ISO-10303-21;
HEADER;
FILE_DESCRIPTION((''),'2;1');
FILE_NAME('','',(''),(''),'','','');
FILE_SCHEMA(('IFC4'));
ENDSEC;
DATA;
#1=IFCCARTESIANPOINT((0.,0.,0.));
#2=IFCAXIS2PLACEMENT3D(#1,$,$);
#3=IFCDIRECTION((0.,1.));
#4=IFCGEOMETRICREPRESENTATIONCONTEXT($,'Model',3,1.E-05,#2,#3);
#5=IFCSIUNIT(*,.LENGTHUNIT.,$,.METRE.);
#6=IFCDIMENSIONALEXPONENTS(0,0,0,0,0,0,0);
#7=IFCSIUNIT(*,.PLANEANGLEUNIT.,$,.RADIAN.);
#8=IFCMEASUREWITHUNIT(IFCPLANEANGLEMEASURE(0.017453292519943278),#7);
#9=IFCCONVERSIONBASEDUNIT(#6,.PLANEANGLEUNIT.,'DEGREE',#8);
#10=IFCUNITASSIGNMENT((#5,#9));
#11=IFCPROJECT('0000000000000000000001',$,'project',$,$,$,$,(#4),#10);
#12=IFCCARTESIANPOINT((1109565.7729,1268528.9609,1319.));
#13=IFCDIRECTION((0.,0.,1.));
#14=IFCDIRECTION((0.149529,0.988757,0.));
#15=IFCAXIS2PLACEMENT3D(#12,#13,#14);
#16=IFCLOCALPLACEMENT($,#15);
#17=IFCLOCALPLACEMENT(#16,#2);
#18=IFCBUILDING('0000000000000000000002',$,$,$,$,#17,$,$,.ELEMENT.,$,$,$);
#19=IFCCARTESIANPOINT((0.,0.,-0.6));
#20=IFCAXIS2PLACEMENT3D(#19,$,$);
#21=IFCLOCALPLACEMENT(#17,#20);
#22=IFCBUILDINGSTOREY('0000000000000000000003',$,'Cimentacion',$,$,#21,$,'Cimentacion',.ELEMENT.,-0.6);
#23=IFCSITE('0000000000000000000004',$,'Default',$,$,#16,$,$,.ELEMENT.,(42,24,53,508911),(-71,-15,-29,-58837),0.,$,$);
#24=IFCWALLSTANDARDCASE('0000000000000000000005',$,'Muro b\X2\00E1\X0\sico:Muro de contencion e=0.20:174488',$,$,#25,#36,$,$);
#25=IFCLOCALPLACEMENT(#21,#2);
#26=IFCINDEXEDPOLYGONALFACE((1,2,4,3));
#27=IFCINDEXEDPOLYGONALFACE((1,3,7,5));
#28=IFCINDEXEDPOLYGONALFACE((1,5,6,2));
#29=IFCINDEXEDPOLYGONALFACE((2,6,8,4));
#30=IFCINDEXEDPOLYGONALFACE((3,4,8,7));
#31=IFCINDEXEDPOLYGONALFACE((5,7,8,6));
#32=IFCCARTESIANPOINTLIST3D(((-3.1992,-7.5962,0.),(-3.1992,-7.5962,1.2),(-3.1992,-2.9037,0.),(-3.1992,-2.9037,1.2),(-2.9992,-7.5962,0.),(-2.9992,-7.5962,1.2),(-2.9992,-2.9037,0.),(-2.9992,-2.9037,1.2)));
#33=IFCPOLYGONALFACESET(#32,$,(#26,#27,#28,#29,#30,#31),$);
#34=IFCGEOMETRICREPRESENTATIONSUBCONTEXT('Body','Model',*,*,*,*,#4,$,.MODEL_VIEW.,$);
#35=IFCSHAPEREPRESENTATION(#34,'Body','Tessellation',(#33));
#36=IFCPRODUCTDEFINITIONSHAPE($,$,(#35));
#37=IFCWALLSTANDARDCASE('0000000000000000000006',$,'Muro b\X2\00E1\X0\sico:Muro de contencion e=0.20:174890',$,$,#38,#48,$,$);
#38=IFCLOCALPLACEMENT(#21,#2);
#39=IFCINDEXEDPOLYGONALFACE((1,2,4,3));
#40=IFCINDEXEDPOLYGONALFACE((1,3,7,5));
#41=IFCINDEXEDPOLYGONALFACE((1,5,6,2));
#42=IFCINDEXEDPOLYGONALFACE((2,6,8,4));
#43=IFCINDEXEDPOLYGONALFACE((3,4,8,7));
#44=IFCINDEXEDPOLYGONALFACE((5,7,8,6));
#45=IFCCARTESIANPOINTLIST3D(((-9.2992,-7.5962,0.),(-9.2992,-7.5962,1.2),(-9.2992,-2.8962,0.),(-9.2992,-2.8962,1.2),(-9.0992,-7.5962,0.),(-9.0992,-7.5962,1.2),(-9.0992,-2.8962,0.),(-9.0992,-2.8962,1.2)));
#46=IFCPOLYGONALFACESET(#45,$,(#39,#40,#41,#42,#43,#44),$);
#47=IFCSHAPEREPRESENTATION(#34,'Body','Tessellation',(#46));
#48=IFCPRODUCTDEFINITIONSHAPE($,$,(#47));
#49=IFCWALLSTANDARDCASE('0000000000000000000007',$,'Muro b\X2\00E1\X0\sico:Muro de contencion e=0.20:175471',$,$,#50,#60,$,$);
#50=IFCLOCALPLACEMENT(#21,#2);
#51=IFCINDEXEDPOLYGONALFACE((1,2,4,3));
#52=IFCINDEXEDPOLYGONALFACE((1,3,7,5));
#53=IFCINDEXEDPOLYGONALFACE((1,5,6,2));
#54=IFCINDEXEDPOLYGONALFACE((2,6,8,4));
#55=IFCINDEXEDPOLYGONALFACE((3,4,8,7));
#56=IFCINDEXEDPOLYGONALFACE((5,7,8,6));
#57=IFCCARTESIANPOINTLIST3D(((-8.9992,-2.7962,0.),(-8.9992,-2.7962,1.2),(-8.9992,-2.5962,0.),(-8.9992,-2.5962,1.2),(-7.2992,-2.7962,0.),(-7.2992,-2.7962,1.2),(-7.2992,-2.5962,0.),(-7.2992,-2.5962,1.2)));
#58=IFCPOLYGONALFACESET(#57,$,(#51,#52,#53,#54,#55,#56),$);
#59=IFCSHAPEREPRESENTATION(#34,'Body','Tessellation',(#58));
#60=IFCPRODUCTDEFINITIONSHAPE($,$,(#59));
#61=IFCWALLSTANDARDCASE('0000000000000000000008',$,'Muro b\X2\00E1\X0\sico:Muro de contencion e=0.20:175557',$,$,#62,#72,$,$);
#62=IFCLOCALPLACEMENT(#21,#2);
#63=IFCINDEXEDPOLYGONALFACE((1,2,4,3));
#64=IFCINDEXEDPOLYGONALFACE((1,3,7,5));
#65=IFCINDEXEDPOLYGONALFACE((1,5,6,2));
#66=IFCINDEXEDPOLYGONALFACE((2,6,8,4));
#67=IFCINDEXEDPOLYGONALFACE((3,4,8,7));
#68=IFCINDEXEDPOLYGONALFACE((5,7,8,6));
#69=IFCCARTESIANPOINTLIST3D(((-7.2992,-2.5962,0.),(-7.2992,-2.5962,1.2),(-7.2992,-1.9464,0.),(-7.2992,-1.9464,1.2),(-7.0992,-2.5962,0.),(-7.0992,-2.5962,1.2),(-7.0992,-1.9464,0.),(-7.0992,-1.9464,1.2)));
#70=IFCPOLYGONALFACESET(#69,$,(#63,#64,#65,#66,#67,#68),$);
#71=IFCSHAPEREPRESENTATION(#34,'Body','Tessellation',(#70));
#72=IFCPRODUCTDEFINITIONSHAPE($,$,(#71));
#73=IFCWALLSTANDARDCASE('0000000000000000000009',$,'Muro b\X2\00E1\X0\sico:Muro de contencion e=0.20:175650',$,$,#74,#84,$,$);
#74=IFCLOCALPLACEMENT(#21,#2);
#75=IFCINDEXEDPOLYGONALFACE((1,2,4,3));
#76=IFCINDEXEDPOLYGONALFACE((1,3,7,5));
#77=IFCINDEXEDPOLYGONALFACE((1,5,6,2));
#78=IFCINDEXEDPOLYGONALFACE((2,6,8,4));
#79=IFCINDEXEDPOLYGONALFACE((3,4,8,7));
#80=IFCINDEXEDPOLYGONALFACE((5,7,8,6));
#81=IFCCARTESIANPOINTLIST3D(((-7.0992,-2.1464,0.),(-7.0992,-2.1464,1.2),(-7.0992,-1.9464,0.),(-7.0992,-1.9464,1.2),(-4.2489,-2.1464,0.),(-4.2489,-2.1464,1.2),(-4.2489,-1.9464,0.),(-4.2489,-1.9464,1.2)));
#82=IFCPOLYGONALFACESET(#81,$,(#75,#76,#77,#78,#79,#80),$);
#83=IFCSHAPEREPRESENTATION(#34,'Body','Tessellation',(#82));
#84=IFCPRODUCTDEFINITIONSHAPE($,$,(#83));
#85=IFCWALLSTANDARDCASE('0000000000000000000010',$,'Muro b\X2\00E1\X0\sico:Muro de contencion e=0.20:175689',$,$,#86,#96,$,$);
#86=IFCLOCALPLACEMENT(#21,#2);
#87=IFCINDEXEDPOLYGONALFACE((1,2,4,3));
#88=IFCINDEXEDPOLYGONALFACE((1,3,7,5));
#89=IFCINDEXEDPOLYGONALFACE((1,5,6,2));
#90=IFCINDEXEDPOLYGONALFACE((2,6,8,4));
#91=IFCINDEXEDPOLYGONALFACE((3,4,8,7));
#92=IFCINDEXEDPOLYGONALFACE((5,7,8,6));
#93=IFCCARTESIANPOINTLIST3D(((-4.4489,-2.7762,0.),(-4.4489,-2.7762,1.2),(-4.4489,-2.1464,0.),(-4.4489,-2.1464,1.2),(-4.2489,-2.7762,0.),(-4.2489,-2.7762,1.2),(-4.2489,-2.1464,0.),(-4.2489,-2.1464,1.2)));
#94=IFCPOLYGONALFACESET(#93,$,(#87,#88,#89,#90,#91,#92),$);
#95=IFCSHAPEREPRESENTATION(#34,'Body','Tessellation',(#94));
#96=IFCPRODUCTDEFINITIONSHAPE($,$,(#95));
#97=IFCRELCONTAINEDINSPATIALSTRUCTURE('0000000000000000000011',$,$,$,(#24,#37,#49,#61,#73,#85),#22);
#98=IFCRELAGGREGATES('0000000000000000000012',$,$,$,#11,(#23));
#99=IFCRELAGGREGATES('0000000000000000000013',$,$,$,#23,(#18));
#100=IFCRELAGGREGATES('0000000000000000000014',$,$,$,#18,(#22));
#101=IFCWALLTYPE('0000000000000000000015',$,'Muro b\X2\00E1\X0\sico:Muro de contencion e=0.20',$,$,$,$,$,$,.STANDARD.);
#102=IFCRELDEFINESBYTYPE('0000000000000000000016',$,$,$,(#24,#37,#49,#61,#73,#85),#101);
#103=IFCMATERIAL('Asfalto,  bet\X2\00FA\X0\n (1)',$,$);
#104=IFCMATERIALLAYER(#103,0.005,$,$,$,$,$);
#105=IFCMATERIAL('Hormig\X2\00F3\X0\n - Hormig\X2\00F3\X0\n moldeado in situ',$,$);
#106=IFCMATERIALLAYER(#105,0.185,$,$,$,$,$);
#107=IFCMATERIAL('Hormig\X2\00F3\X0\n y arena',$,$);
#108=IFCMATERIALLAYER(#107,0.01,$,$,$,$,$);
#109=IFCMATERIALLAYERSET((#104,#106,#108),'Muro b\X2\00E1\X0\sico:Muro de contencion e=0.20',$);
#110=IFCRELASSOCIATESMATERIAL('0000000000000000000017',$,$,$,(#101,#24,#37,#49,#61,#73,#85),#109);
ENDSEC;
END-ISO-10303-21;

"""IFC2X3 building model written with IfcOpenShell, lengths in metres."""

from ifc_helpers import new_model, entity, si_unit, converted_unit, direction, frame, frame_2d, origin, place, context, subcontext, project, spatial, rectangle, extrude, material, layer, layer_set, layer_usage, type_object, element, save


model = new_model("IFC2X3")

# Units and contexts
model_context = context("Model", 3, precision=1e-05, world=origin(), true_north=direction((0.0, 1.0)))
body_context = subcontext(model_context, "Body", "Model", "MODEL_VIEW")
ifc_project = project(units=[si_unit("LENGTHUNIT", "METRE"), converted_unit("PLANEANGLEUNIT", "DEGREE", entity("IfcPlaneAngleMeasure", 0.017453292519943278), si_unit("PLANEANGLEUNIT", "RADIAN"), dimensions=[0, 0, 0, 0, 0, 0, 0])], contexts=[model_context])

# Site, building, storey
site_placement = place(None, frame((1109565.7729, 1268528.9609, 1319.0), z_axis=(0.0, 0.0, 1.0), x_axis=(0.149529, 0.988757, 0.0)))
site = spatial("IfcSite", under=ifc_project, at=site_placement, Name="Default", CompositionType="ELEMENT", RefLatitude=(42, 24, 53, 508911), RefLongitude=(-71, -15, -29, -58837), RefElevation=0.0)
building_placement = place(site_placement, origin())
building = spatial("IfcBuilding", under=site, at=building_placement, CompositionType="ELEMENT")
storey_placement = place(building_placement, frame((0.0, 0.0, -0.6)))
storey = spatial("IfcBuildingStorey", under=building, at=storey_placement, Name="Cimentacion", LongName="Cimentacion", CompositionType="ELEMENT", Elevation=-0.6)

# Walls
ifc_material_1 = material(Name="Asfalto,  betún (1)")
ifc_layer_1 = layer(ifc_material_1, 0.005)
ifc_material_2 = material(Name="Hormigón - Hormigón moldeado in situ")
ifc_layer_2 = layer(ifc_material_2, 0.185)
ifc_material_3 = material(Name="Hormigón y arena")
ifc_layer_3 = layer(ifc_material_3, 0.01)
ifc_layer_set = layer_set([ifc_layer_1, ifc_layer_2, ifc_layer_3], Name="Muro básico:Muro de contencion e=0.20")
ifc_layer_usage_1 = layer_usage(ifc_layer_set, "AXIS2", "POSITIVE", -0.1)
wall_type = type_object("IfcWallType", Name="Muro básico:Muro de contencion e=0.20", PredefinedType="STANDARD", material=ifc_layer_set)
wall_1_placement = place(storey_placement, frame((-3.0992, -7.5962, 0.0), z_axis=(0.0, 0.0, 1.0), x_axis=(0.0, 1.0, 0.0)))
element("IfcWallStandardCase", 1, at=wall_1_placement, inside=storey, type_object=wall_type, material=ifc_layer_usage_1, Name="Muro básico:Muro de contencion e=0.20:174488", context=body_context, shape_type="SweptSolid", body=[
    extrude(rectangle(XDim=4.6925, YDim=0.2, at=frame_2d((2.3462, 0.0), x_axis=(-1.0, 0.0))), origin(), (0.0, 0.0, 1.0), 1.2),
])
ifc_layer_usage_2 = layer_usage(ifc_layer_set, "AXIS2", "NEGATIVE", 0.1)
wall_2_placement = place(storey_placement, frame((-9.1992, -7.5962, 0.0), z_axis=(0.0, 0.0, 1.0), x_axis=(0.0, 1.0, 0.0)))
element("IfcWallStandardCase", 2, at=wall_2_placement, inside=storey, type_object=wall_type, material=ifc_layer_usage_2, Name="Muro básico:Muro de contencion e=0.20:174890", context=body_context, shape_type="SweptSolid", body=[
    extrude(rectangle(XDim=4.7, YDim=0.2, at=frame_2d((2.35, 0.0), x_axis=(-1.0, 0.0))), origin(), (0.0, 0.0, 1.0), 1.2),
])
ifc_layer_usage_3 = layer_usage(ifc_layer_set, "AXIS2", "NEGATIVE", 0.1)
wall_3_placement = place(storey_placement, frame((-8.9992, -2.6962, 0.0)))
element("IfcWallStandardCase", 3, at=wall_3_placement, inside=storey, type_object=wall_type, material=ifc_layer_usage_3, Name="Muro básico:Muro de contencion e=0.20:175471", context=body_context, shape_type="SweptSolid", body=[
    extrude(rectangle(XDim=1.7, YDim=0.2, at=frame_2d((0.85, 0.0), x_axis=(-1.0, 0.0))), origin(), (0.0, 0.0, 1.0), 1.2),
])
ifc_layer_usage_4 = layer_usage(ifc_layer_set, "AXIS2", "NEGATIVE", 0.1)
wall_4_placement = place(storey_placement, frame((-7.1992, -2.5962, 0.0), z_axis=(0.0, 0.0, 1.0), x_axis=(0.0, 1.0, 0.0)))
element("IfcWallStandardCase", 4, at=wall_4_placement, inside=storey, type_object=wall_type, material=ifc_layer_usage_4, Name="Muro básico:Muro de contencion e=0.20:175557", context=body_context, shape_type="SweptSolid", body=[
    extrude(rectangle(XDim=0.6498, YDim=0.2, at=frame_2d((0.3249, 0.0), x_axis=(-1.0, 0.0))), origin(), (0.0, 0.0, 1.0), 1.2),
])
ifc_layer_usage_5 = layer_usage(ifc_layer_set, "AXIS2", "NEGATIVE", 0.1)
wall_5_placement = place(storey_placement, frame((-7.0992, -2.0464, 0.0)))
element("IfcWallStandardCase", 5, at=wall_5_placement, inside=storey, type_object=wall_type, material=ifc_layer_usage_5, Name="Muro básico:Muro de contencion e=0.20:175650", context=body_context, shape_type="SweptSolid", body=[
    extrude(rectangle(XDim=2.8504, YDim=0.2, at=frame_2d((1.4252, 0.0), x_axis=(-1.0, 0.0))), origin(), (0.0, 0.0, 1.0), 1.2),
])
ifc_layer_usage_6 = layer_usage(ifc_layer_set, "AXIS2", "NEGATIVE", 0.1)
wall_6_placement = place(storey_placement, frame((-4.3489, -2.1464, 0.0), z_axis=(0.0, 0.0, 1.0), x_axis=(0.0, -1.0, 0.0)))
element("IfcWallStandardCase", 6, at=wall_6_placement, inside=storey, type_object=wall_type, material=ifc_layer_usage_6, Name="Muro básico:Muro de contencion e=0.20:175689", context=body_context, shape_type="SweptSolid", body=[
    extrude(rectangle(XDim=0.6298, YDim=0.2, at=frame_2d((0.3149, 0.0), x_axis=(-1.0, 0.0))), origin(), (0.0, 0.0, 1.0), 1.2),
])

save(model, "model.ifc")
